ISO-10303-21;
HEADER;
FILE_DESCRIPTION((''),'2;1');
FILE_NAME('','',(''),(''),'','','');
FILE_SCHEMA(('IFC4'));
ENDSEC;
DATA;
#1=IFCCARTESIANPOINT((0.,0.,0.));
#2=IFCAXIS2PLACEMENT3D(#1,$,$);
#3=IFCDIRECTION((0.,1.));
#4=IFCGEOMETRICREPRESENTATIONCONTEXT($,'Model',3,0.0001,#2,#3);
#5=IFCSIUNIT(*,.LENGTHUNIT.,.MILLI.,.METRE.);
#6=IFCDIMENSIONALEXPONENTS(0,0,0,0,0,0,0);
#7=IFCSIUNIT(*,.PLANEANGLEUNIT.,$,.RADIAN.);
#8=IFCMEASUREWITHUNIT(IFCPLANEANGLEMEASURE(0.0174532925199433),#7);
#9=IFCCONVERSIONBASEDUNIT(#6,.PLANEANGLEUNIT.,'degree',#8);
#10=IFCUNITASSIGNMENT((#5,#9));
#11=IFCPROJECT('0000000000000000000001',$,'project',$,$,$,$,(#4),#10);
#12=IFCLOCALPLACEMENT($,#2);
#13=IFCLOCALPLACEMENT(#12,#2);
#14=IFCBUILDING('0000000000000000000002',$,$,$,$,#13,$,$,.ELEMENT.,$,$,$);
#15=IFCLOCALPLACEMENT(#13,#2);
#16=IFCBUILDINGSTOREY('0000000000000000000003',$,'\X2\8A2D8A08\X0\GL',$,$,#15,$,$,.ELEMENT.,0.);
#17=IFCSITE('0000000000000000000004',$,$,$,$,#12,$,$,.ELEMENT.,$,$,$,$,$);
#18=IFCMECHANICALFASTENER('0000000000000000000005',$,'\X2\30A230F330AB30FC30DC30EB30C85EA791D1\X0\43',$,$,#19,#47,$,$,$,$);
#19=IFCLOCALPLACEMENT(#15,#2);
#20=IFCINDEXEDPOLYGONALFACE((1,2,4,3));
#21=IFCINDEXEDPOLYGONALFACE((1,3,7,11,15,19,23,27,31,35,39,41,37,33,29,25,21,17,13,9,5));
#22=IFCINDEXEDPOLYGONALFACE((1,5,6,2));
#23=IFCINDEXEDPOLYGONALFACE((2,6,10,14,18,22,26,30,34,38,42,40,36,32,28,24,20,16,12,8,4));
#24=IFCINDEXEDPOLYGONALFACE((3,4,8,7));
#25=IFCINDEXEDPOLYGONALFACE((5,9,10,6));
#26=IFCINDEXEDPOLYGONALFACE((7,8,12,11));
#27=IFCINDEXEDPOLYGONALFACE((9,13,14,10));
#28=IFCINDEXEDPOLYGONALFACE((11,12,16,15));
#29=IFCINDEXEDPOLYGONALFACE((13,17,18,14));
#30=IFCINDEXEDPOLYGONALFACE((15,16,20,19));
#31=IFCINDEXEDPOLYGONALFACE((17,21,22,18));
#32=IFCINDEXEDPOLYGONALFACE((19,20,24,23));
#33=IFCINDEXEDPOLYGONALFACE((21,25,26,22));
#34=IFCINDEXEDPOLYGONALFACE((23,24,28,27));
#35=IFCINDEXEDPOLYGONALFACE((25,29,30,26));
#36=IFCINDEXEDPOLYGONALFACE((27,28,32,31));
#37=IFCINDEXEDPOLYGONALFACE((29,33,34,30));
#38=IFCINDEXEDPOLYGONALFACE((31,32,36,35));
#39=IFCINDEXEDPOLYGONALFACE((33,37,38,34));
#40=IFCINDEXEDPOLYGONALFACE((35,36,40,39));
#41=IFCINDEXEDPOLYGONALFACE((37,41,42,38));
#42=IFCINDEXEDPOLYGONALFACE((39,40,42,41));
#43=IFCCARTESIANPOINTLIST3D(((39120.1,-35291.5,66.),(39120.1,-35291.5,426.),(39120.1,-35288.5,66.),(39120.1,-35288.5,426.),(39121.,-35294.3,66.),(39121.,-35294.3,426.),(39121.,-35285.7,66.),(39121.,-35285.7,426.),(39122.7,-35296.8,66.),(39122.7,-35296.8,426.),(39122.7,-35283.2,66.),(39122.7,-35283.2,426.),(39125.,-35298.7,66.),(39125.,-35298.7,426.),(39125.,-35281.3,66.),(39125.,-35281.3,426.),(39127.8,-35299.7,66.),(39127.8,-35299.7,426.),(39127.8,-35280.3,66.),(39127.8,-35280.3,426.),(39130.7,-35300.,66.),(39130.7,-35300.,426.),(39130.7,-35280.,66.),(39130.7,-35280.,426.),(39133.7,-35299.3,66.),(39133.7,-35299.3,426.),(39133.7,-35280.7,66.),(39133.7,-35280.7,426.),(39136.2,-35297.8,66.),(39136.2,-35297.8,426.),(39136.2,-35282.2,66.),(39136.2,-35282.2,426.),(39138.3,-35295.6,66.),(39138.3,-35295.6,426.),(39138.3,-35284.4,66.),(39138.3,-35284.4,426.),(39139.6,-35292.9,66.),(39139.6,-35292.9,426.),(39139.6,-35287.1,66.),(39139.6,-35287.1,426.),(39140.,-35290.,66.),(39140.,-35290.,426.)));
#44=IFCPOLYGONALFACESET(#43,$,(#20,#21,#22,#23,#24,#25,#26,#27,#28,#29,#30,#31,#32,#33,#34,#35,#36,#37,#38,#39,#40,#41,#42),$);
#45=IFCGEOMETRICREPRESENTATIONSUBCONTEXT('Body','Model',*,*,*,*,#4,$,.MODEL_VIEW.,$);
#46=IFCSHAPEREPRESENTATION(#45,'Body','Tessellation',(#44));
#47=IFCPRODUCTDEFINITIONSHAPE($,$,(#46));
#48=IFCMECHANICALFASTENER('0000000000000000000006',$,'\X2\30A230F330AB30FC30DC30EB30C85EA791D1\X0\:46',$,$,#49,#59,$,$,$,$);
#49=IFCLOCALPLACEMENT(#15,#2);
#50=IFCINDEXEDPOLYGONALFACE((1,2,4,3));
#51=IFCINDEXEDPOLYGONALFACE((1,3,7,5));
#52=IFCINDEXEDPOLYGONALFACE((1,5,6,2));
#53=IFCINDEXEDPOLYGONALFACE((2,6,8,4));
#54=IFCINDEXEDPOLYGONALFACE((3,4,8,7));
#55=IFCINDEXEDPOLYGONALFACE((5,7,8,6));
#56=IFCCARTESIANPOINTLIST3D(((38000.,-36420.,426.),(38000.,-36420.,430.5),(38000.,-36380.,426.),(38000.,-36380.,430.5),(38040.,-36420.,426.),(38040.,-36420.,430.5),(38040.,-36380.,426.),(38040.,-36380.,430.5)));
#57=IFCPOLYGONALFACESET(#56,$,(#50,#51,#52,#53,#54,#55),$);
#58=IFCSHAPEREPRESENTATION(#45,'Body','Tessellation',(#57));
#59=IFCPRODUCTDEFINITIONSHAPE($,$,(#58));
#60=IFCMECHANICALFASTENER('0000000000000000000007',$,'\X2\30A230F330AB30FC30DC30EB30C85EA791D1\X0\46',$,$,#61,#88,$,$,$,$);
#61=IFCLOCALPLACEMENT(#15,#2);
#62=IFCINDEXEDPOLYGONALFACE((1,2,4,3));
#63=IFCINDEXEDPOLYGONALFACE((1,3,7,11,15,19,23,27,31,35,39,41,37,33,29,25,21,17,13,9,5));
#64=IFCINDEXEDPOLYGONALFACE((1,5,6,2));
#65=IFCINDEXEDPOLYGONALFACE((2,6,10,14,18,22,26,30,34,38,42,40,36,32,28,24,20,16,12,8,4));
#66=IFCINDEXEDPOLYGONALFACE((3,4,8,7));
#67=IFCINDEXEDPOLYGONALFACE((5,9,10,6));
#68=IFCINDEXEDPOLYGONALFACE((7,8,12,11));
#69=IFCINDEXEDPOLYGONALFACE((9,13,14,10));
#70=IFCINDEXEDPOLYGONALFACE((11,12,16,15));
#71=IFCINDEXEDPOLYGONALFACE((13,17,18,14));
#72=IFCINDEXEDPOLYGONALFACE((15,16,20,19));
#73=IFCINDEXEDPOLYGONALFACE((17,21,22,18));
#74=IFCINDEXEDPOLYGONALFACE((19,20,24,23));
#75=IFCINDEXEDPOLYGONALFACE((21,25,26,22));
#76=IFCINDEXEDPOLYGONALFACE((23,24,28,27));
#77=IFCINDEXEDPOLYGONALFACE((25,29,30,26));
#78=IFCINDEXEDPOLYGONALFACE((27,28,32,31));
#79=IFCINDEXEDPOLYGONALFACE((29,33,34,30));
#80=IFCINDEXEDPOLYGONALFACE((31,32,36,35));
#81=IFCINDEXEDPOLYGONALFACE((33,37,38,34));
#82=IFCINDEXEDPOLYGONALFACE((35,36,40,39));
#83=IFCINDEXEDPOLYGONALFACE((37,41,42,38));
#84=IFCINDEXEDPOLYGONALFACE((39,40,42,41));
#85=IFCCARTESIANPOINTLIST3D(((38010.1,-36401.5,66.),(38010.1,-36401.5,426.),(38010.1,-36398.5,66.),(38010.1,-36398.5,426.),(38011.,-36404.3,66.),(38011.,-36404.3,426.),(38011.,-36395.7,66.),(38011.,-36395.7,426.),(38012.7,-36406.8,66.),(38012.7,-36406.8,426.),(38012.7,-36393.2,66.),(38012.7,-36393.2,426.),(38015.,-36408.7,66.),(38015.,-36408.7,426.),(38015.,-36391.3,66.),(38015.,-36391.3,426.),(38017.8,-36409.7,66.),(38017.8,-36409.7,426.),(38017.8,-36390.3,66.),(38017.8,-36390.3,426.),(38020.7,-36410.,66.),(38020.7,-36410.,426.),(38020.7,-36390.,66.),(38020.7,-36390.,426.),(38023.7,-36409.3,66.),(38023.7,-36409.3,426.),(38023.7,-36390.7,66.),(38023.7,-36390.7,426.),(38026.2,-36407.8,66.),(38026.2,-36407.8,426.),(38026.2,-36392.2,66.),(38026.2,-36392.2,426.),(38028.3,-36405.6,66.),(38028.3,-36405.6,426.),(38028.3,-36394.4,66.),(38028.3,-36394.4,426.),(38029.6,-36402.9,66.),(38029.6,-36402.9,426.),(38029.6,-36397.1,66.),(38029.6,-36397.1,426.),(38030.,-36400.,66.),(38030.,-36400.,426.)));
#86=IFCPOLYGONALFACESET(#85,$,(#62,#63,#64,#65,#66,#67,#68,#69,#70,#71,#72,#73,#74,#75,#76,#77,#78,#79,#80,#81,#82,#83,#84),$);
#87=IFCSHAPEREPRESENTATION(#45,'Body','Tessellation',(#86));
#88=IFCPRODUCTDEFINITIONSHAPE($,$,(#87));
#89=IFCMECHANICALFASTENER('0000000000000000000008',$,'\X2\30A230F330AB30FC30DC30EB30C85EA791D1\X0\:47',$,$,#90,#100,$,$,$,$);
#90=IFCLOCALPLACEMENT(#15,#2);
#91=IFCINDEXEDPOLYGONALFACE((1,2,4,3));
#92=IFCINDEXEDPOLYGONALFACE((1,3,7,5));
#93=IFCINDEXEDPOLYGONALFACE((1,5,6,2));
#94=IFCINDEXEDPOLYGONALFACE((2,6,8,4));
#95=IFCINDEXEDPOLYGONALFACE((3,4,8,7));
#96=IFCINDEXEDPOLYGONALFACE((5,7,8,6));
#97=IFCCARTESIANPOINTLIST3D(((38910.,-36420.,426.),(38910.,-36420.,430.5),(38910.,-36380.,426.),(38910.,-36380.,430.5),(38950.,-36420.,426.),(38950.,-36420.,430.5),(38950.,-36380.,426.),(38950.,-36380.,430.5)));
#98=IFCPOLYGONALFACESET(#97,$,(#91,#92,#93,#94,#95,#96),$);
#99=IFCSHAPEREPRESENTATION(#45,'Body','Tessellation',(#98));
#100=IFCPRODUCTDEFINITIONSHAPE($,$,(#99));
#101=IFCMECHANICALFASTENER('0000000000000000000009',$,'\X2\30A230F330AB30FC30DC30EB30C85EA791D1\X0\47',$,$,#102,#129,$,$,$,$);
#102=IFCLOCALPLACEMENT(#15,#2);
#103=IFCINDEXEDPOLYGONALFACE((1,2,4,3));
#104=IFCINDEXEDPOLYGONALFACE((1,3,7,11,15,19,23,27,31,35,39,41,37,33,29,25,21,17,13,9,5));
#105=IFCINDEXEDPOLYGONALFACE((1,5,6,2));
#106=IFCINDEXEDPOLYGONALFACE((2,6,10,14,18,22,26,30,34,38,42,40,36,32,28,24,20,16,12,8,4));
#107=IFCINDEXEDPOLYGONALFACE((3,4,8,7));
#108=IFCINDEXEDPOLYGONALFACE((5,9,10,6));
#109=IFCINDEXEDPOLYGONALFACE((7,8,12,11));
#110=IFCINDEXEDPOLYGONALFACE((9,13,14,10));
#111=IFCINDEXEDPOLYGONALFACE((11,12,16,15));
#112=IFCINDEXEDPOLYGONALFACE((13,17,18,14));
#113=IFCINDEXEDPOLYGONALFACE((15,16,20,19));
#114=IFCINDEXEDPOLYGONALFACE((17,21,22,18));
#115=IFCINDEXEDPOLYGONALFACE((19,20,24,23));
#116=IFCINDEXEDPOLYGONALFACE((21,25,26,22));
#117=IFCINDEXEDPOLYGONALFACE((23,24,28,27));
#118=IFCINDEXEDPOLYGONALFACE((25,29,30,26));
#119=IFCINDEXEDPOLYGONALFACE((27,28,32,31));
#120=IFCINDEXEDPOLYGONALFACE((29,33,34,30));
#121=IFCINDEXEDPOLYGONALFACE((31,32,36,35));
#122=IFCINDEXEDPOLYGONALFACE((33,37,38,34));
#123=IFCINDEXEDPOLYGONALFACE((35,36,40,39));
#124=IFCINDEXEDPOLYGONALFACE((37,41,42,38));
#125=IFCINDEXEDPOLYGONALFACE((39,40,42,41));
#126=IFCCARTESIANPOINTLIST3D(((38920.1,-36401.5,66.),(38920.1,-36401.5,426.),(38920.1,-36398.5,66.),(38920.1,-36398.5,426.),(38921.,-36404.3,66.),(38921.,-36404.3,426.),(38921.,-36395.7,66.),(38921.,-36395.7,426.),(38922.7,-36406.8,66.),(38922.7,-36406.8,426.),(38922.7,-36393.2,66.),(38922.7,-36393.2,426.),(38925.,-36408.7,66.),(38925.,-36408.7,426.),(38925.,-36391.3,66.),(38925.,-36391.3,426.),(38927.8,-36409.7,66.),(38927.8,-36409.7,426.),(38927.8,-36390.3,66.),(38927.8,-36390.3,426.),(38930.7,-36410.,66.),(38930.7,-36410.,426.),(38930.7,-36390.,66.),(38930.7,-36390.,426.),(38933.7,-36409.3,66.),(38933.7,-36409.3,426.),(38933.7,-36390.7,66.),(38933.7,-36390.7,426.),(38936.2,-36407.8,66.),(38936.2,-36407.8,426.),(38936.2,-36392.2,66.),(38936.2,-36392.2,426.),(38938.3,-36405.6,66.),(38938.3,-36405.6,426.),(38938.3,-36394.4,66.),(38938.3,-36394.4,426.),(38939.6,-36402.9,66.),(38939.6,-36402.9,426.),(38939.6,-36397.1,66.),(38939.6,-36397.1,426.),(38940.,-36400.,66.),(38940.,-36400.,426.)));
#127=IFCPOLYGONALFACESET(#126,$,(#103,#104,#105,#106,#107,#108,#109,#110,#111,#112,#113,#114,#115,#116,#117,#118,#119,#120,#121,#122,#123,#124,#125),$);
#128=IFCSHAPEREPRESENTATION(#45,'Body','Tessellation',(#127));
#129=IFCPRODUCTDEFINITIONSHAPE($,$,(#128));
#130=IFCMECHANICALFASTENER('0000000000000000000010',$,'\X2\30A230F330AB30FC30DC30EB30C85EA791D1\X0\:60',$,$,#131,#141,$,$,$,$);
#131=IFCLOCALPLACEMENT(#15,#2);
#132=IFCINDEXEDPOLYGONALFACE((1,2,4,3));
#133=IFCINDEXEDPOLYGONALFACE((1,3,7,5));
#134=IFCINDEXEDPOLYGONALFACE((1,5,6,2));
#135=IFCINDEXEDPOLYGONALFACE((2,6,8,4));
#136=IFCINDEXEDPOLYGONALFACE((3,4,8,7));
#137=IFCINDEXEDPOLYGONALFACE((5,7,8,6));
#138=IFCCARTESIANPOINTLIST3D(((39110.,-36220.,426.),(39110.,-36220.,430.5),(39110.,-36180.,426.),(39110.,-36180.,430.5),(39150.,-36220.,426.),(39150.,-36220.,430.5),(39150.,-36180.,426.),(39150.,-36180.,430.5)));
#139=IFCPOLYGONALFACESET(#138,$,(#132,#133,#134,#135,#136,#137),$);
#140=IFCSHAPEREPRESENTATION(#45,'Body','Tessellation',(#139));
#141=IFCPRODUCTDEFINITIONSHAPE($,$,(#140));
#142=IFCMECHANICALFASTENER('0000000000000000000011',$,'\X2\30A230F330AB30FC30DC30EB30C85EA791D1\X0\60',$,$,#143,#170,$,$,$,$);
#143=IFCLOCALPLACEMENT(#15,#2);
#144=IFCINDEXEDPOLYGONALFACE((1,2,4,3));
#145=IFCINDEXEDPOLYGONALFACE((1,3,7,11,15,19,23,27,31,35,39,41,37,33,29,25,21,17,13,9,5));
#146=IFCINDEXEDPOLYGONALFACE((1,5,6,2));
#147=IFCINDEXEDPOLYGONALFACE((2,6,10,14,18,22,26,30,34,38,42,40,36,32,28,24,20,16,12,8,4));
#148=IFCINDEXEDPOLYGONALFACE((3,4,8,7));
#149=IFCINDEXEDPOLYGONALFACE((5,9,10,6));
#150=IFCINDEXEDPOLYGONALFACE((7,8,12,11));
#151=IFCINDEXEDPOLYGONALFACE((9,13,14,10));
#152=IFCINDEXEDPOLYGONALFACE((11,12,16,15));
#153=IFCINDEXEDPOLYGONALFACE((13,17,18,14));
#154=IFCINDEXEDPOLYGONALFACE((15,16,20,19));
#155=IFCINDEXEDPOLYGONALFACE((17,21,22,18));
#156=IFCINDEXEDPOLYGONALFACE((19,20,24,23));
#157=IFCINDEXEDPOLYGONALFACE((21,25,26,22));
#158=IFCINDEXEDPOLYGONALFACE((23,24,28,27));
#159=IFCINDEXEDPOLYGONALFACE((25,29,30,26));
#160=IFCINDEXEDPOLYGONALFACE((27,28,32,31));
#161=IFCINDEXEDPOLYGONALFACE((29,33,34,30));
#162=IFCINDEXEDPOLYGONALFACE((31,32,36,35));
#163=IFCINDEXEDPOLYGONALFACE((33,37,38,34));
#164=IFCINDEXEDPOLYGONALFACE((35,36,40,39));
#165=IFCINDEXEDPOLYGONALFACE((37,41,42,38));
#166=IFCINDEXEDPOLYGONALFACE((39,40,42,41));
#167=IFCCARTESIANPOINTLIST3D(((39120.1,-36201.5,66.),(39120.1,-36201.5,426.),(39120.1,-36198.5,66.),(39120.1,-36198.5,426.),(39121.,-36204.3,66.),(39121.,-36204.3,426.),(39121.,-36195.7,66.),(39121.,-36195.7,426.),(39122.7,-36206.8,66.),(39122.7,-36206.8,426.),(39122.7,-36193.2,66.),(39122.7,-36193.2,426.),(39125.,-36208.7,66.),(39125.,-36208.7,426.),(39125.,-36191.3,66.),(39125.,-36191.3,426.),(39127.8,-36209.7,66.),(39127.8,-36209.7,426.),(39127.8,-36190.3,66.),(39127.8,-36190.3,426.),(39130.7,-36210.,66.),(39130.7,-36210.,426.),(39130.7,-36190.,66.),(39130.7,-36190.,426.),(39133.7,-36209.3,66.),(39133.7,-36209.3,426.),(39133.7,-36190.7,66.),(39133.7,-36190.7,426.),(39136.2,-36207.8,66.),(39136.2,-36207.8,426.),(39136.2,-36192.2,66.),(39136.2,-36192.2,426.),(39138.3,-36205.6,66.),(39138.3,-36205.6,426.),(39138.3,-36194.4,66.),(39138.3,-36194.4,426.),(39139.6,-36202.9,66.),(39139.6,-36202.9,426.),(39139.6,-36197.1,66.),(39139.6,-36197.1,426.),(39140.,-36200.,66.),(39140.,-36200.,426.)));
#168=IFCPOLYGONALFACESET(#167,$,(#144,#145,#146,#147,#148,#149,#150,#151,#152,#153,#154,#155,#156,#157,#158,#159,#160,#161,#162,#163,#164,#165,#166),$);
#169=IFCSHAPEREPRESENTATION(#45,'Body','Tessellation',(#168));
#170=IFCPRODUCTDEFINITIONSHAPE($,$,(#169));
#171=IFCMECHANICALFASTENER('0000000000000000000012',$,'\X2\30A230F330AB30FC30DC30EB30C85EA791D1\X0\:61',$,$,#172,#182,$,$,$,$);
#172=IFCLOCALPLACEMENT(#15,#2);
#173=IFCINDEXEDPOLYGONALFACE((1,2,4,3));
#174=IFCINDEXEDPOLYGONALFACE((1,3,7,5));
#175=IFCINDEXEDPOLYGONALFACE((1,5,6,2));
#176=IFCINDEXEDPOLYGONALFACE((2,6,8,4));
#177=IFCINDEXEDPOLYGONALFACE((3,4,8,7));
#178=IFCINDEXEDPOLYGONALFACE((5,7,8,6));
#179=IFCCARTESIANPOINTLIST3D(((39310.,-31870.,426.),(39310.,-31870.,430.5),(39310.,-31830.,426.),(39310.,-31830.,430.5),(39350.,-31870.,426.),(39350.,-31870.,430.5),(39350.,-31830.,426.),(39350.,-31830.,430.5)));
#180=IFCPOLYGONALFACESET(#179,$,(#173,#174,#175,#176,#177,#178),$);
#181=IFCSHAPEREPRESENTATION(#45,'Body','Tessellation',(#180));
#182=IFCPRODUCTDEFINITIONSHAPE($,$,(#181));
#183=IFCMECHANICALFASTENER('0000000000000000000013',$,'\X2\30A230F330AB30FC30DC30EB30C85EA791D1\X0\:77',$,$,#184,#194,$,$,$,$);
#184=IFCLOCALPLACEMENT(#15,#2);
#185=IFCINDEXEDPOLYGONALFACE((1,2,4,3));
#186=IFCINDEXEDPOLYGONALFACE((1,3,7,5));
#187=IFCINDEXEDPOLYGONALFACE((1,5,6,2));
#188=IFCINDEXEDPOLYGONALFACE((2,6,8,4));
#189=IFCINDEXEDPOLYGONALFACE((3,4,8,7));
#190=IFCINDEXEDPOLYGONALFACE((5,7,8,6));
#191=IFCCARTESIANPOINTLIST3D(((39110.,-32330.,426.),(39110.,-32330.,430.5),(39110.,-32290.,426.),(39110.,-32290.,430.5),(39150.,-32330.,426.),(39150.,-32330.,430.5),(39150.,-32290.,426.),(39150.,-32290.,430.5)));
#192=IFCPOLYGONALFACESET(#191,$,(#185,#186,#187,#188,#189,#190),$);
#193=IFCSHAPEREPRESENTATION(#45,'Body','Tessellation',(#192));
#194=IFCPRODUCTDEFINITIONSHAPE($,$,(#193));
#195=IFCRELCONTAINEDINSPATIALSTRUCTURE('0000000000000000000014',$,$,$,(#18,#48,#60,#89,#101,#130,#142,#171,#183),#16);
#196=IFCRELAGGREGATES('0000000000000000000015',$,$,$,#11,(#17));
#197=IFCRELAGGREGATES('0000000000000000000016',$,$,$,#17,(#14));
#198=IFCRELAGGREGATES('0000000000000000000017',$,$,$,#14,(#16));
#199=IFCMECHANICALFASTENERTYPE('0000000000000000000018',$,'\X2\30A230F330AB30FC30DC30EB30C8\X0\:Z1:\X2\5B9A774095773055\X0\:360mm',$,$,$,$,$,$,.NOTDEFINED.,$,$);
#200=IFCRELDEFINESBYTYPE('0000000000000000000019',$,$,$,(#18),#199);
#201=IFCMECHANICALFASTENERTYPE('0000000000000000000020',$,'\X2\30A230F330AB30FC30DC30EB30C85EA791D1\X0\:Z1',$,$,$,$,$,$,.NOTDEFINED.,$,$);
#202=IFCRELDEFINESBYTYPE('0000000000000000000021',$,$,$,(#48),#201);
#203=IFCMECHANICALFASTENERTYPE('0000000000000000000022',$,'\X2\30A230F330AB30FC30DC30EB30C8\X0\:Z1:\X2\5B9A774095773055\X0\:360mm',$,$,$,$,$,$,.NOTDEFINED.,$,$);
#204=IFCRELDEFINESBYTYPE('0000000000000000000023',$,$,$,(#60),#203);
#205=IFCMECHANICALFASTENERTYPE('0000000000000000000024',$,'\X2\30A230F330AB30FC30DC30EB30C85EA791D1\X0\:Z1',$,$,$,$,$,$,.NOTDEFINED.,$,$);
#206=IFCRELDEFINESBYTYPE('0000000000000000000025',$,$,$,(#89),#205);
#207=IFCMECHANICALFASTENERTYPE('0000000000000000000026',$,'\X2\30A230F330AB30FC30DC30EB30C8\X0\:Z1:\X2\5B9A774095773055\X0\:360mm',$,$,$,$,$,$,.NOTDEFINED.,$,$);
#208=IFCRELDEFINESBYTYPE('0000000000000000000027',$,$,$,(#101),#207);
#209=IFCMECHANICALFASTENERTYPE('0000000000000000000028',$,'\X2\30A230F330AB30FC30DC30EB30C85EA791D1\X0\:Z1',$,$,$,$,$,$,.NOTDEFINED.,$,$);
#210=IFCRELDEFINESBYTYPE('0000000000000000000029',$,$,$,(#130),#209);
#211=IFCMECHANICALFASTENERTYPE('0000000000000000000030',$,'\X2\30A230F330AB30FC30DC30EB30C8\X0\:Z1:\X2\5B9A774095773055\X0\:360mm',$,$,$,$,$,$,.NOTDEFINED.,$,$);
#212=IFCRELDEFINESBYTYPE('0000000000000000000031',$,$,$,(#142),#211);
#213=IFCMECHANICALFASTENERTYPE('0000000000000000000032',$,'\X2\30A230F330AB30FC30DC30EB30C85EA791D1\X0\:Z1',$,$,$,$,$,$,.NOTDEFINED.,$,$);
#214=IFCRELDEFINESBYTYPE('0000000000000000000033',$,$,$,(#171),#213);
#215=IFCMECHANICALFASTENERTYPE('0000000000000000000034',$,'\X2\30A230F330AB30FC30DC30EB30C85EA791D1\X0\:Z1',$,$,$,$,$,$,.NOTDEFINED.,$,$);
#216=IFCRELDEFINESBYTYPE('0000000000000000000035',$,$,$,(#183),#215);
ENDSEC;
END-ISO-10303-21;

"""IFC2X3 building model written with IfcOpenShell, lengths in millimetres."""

from ifc_helpers import new_model, entity, si_unit, converted_unit, direction, frame, origin, origin_with_axes, origin_2d, place, context, subcontext, project, spatial, rectangle, circle, extrude, type_object, element, save


model = new_model("IFC2X3")

# Units and contexts
model_context = context("Model", 3, precision=0.0001, world=origin(), true_north=direction((0.0, 1.0)))
body_context = subcontext(model_context, "Body", "Model", "MODEL_VIEW")
ifc_project = project(units=[si_unit("LENGTHUNIT", "METRE", prefix="MILLI"), converted_unit("PLANEANGLEUNIT", "degree", entity("IfcPlaneAngleMeasure", 0.0174532925199433), si_unit("PLANEANGLEUNIT", "RADIAN"), dimensions=[0, 0, 0, 0, 0, 0, 0])], contexts=[model_context])

# Site, building, storey
site_placement = place(None, origin())
site = spatial("IfcSite", under=ifc_project, at=site_placement, CompositionType="ELEMENT")
building_placement = place(site_placement, origin())
building = spatial("IfcBuilding", under=site, at=building_placement, CompositionType="ELEMENT")
storey_placement = place(building_placement, origin())
storey = spatial("IfcBuildingStorey", under=building, at=storey_placement, Name="設計GL", CompositionType="ELEMENT", Elevation=0.0)

# Mechanical fasteners
mechanical_fastener_type_1 = type_object("IfcMechanicalFastenerType", Name="アンカーボルト:Z1:定着長さ:360mm")
mechanical_fastener_1_placement = place(storey_placement, frame((39130.0, -35290.0, 66.0)))
element("IfcMechanicalFastener", 1, at=mechanical_fastener_1_placement, inside=storey, type_object=mechanical_fastener_type_1, Name="アンカーボルト座金43", context=body_context, shape_type="SweptSolid", body=[
    extrude(circle(Radius=10.0, at=origin_2d()), origin_with_axes(), (0.0, 0.0, 1.0), 360.0),
])
mechanical_fastener_type_2 = type_object("IfcMechanicalFastenerType", Name="アンカーボルト座金:Z1")
mechanical_fastener_2_placement = place(storey_placement, frame((38020.0, -36400.0, 426.0)))
element("IfcMechanicalFastener", 2, at=mechanical_fastener_2_placement, inside=storey, type_object=mechanical_fastener_type_2, Name="アンカーボルト座金:46", context=body_context, shape_type="SweptSolid", body=[
    extrude(rectangle(XDim=40.0, YDim=40.0, at=origin_2d()), origin_with_axes(), (0.0, 0.0, 1.0), 4.5),
])
mechanical_fastener_type_3 = type_object("IfcMechanicalFastenerType", Name="アンカーボルト:Z1:定着長さ:360mm")
mechanical_fastener_3_placement = place(storey_placement, frame((38020.0, -36400.0, 66.0)))
element("IfcMechanicalFastener", 3, at=mechanical_fastener_3_placement, inside=storey, type_object=mechanical_fastener_type_3, Name="アンカーボルト座金46", context=body_context, shape_type="SweptSolid", body=[
    extrude(circle(Radius=10.0, at=origin_2d()), origin_with_axes(), (0.0, 0.0, 1.0), 360.0),
])
mechanical_fastener_type_4 = type_object("IfcMechanicalFastenerType", Name="アンカーボルト座金:Z1")
mechanical_fastener_4_placement = place(storey_placement, frame((38930.0, -36400.0, 426.0)))
element("IfcMechanicalFastener", 4, at=mechanical_fastener_4_placement, inside=storey, type_object=mechanical_fastener_type_4, Name="アンカーボルト座金:47", context=body_context, shape_type="SweptSolid", body=[
    extrude(rectangle(XDim=40.0, YDim=40.0, at=origin_2d()), origin_with_axes(), (0.0, 0.0, 1.0), 4.5),
])
mechanical_fastener_type_5 = type_object("IfcMechanicalFastenerType", Name="アンカーボルト:Z1:定着長さ:360mm")
mechanical_fastener_5_placement = place(storey_placement, frame((38930.0, -36400.0, 66.0)))
element("IfcMechanicalFastener", 5, at=mechanical_fastener_5_placement, inside=storey, type_object=mechanical_fastener_type_5, Name="アンカーボルト座金47", context=body_context, shape_type="SweptSolid", body=[
    extrude(circle(Radius=10.0, at=origin_2d()), origin_with_axes(), (0.0, 0.0, 1.0), 360.0),
])
mechanical_fastener_type_6 = type_object("IfcMechanicalFastenerType", Name="アンカーボルト座金:Z1")
mechanical_fastener_6_placement = place(storey_placement, frame((39130.0, -36200.0, 426.0)))
element("IfcMechanicalFastener", 6, at=mechanical_fastener_6_placement, inside=storey, type_object=mechanical_fastener_type_6, Name="アンカーボルト座金:60", context=body_context, shape_type="SweptSolid", body=[
    extrude(rectangle(XDim=40.0, YDim=40.0, at=origin_2d()), origin_with_axes(), (0.0, 0.0, 1.0), 4.5),
])
mechanical_fastener_type_7 = type_object("IfcMechanicalFastenerType", Name="アンカーボルト:Z1:定着長さ:360mm")
mechanical_fastener_7_placement = place(storey_placement, frame((39130.0, -36200.0, 66.0)))
element("IfcMechanicalFastener", 7, at=mechanical_fastener_7_placement, inside=storey, type_object=mechanical_fastener_type_7, Name="アンカーボルト座金60", context=body_context, shape_type="SweptSolid", body=[
    extrude(circle(Radius=10.0, at=origin_2d()), origin_with_axes(), (0.0, 0.0, 1.0), 360.0),
])
mechanical_fastener_type_8 = type_object("IfcMechanicalFastenerType", Name="アンカーボルト座金:Z1")
mechanical_fastener_8_placement = place(storey_placement, frame((39330.0, -31850.0, 426.0)))
element("IfcMechanicalFastener", 8, at=mechanical_fastener_8_placement, inside=storey, type_object=mechanical_fastener_type_8, Name="アンカーボルト座金:61", context=body_context, shape_type="SweptSolid", body=[
    extrude(rectangle(XDim=40.0, YDim=40.0, at=origin_2d()), origin_with_axes(), (0.0, 0.0, 1.0), 4.5),
])
mechanical_fastener_type_9 = type_object("IfcMechanicalFastenerType", Name="アンカーボルト座金:Z1")
mechanical_fastener_9_placement = place(storey_placement, frame((39130.0, -32310.0, 426.0)))
element("IfcMechanicalFastener", 9, at=mechanical_fastener_9_placement, inside=storey, type_object=mechanical_fastener_type_9, Name="アンカーボルト座金:77", context=body_context, shape_type="SweptSolid", body=[
    extrude(rectangle(XDim=40.0, YDim=40.0, at=origin_2d()), origin_with_axes(), (0.0, 0.0, 1.0), 4.5),
])

save(model, "model.ifc")
